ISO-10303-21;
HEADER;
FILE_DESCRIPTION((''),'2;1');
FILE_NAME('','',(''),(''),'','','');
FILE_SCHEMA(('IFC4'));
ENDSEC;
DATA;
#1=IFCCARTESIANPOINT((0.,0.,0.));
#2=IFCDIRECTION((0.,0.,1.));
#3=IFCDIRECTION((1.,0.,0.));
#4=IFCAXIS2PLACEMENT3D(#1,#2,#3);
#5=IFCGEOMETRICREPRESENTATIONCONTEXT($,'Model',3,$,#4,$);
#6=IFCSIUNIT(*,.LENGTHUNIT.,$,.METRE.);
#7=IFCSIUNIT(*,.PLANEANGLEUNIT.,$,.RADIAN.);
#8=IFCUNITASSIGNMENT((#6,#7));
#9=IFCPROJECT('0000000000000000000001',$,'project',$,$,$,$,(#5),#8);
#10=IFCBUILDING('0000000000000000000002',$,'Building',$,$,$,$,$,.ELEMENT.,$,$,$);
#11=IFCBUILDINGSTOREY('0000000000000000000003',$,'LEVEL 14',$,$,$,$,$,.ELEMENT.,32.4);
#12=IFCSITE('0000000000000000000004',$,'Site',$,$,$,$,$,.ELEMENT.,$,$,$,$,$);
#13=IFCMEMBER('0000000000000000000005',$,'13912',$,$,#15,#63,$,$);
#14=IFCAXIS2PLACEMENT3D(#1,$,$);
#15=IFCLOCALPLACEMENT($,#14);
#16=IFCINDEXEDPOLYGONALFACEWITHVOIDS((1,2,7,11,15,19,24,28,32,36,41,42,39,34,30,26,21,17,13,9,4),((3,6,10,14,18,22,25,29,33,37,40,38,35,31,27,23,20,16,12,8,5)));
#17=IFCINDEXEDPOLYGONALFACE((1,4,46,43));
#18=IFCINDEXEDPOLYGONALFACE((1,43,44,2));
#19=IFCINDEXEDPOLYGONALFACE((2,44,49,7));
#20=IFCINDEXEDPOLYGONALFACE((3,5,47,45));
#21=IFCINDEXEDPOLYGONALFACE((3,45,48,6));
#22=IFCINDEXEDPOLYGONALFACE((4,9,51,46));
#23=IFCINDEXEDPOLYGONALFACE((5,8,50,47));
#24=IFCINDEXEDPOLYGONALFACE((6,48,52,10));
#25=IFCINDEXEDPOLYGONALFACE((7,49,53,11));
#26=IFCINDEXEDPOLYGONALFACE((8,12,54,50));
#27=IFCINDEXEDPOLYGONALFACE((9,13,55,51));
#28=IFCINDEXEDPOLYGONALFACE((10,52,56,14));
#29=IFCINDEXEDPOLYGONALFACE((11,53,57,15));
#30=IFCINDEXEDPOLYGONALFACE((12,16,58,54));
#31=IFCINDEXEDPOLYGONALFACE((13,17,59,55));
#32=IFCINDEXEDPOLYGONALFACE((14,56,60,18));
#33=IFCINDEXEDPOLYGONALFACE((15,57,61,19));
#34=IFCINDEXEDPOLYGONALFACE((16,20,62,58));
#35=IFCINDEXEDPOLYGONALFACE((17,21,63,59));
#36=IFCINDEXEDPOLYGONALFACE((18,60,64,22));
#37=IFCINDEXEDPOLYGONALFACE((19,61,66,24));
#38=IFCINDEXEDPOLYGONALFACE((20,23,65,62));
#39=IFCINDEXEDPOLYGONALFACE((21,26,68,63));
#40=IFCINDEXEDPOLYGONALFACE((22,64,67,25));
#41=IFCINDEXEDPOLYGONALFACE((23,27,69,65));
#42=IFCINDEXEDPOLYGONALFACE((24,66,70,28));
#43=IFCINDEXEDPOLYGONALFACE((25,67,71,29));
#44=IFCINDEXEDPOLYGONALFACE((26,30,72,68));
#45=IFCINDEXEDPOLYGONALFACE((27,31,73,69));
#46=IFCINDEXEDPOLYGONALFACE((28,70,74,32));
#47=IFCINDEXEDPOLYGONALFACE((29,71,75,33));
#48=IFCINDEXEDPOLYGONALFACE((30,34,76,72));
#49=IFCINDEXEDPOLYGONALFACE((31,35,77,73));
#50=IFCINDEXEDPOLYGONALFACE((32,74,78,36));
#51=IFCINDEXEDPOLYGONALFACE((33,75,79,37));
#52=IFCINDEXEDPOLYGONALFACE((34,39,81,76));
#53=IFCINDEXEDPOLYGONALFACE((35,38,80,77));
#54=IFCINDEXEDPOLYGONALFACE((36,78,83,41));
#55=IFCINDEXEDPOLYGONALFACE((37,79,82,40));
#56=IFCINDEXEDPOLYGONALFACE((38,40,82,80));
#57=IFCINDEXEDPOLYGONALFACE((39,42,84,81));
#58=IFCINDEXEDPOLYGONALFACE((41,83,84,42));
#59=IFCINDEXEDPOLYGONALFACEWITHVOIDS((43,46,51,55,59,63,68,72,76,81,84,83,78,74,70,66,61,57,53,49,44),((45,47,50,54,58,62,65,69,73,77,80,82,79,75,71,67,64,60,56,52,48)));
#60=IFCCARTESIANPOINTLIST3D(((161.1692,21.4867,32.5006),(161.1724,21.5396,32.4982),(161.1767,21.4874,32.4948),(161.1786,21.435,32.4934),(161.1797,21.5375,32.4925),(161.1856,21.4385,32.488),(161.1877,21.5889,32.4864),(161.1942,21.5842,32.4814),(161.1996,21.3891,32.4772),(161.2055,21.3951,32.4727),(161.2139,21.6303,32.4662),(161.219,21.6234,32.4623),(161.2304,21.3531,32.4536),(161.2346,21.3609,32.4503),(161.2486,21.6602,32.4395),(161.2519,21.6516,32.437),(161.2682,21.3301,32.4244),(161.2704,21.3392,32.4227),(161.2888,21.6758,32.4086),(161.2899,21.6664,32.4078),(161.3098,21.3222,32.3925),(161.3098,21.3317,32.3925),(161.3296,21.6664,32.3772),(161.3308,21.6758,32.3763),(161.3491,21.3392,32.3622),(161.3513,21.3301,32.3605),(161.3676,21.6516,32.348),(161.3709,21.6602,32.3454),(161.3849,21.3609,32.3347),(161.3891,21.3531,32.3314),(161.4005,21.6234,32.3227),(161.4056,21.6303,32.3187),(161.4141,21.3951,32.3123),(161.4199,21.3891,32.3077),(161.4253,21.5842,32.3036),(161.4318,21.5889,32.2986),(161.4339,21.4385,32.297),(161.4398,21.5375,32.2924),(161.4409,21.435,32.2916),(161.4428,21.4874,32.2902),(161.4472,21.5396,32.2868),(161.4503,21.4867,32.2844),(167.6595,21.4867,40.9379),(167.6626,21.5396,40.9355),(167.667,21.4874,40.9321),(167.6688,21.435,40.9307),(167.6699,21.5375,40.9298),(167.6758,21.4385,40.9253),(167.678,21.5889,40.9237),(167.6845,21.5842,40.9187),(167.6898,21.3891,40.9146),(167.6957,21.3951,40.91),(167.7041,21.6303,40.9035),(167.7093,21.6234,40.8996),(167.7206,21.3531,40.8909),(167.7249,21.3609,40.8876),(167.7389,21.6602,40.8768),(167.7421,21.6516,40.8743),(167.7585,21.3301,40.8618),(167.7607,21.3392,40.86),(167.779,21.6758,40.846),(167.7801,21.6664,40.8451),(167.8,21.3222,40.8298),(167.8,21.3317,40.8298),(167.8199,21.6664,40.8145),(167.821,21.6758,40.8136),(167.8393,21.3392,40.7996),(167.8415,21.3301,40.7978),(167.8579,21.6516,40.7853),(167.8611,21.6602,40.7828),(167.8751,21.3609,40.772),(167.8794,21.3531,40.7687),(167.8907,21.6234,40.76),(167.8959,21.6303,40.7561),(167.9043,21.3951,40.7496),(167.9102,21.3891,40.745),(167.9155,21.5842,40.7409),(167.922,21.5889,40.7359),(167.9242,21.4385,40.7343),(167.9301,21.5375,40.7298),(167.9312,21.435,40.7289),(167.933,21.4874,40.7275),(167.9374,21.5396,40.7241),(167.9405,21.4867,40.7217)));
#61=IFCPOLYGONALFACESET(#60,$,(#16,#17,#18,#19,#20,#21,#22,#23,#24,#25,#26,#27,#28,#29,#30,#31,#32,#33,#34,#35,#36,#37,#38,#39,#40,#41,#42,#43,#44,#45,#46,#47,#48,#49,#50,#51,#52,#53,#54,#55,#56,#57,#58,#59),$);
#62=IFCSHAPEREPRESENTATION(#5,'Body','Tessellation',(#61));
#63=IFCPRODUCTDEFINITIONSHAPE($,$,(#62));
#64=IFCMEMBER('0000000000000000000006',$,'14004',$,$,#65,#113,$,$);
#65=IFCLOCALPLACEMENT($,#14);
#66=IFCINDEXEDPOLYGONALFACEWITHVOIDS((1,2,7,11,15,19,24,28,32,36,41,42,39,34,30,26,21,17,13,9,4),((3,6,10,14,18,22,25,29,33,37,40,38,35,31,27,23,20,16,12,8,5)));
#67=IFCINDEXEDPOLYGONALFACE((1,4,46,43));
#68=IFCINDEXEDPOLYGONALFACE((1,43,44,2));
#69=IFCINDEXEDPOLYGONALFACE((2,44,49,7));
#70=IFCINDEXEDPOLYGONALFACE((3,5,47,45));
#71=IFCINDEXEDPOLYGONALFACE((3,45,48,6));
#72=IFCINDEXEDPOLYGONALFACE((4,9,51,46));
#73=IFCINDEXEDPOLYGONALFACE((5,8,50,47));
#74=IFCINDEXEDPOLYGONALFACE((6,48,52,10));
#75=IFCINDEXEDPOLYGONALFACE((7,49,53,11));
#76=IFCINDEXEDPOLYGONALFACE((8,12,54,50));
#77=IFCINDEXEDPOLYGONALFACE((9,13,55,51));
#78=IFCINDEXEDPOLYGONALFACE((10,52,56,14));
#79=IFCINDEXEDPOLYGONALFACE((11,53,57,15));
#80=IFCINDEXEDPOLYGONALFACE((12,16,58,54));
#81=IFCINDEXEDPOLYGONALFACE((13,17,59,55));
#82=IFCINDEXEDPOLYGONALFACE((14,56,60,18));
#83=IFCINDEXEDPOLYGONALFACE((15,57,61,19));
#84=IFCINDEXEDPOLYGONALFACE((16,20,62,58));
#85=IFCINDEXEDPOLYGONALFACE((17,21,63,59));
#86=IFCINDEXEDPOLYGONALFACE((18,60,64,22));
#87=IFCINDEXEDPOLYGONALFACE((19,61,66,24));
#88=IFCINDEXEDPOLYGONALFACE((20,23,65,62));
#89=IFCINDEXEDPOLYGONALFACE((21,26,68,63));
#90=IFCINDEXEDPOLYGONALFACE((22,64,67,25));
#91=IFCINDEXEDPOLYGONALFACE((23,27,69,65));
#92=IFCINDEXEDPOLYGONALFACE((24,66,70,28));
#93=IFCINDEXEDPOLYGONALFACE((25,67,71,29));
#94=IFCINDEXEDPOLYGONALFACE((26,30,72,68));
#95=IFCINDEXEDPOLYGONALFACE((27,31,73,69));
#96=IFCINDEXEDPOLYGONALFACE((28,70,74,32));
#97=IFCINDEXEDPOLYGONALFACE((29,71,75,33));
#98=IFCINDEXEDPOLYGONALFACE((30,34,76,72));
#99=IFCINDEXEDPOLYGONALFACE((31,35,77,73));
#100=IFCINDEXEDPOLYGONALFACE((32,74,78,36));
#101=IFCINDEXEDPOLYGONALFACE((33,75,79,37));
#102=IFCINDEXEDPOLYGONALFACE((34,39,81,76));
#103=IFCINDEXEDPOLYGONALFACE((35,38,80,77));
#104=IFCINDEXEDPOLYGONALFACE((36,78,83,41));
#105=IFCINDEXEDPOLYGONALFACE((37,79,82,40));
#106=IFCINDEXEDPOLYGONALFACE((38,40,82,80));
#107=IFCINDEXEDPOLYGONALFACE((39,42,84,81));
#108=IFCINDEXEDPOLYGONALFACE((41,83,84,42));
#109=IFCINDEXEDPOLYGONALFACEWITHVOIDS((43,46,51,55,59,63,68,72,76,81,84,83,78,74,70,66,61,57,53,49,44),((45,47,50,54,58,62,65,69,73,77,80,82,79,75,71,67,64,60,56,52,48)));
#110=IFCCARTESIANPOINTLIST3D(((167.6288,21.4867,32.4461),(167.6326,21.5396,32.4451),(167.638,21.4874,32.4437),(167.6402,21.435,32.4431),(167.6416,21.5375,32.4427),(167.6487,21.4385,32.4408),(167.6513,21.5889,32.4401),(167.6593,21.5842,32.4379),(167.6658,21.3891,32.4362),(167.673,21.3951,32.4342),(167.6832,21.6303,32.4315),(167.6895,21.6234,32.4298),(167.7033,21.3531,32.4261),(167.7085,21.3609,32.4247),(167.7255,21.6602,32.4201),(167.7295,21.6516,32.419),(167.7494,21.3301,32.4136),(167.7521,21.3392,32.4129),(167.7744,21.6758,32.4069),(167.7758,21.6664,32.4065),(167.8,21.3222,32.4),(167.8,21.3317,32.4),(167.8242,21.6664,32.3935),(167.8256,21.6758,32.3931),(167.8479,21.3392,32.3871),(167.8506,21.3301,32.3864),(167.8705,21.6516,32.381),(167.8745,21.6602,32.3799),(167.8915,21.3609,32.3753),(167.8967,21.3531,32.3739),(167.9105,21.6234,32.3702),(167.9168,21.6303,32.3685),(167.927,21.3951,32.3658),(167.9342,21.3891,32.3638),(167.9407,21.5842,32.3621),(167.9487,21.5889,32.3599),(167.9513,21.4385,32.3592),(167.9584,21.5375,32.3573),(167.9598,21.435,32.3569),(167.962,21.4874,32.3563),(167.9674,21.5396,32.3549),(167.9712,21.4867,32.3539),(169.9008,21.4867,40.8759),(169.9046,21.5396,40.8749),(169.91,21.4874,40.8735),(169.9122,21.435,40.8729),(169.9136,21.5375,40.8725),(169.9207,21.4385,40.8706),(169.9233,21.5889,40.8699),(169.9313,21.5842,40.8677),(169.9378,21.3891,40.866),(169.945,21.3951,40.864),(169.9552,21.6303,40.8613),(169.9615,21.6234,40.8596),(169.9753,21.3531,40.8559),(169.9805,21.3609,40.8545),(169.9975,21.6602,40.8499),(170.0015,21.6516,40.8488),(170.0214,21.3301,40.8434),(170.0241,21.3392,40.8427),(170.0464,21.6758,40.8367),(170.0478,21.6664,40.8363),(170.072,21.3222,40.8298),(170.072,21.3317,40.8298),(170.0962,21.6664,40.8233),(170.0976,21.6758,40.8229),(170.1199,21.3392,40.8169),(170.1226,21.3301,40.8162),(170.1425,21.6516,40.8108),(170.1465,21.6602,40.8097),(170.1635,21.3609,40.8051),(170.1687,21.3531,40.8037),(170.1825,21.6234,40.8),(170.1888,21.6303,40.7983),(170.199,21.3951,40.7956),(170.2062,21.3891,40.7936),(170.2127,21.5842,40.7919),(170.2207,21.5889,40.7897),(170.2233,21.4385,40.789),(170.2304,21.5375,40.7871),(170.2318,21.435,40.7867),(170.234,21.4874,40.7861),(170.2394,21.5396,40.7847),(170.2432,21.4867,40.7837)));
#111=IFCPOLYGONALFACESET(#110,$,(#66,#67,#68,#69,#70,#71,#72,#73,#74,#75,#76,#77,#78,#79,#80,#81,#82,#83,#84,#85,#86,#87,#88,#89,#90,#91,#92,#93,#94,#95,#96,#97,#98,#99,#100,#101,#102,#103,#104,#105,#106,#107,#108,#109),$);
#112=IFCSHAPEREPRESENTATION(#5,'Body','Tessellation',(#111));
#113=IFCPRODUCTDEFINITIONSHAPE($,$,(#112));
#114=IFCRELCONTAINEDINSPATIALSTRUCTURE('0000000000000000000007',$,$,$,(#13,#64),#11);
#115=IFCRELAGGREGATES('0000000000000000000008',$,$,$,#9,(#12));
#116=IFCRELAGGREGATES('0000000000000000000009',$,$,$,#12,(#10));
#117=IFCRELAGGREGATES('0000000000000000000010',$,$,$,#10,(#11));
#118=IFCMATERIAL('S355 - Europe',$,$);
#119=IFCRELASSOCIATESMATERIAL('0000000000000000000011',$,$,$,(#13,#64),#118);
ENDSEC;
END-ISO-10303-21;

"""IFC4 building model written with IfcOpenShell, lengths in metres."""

from ifc_helpers import new_model, si_unit, frame, origin_with_axes, origin_2d_with_axis, place, context, project, spatial, hollow_circle, extrude, material, material_profile, profile_set, profile_usage, element, save


model = new_model("IFC4")

# Units and contexts
model_context = context("Model", 3, world=origin_with_axes())
ifc_project = project(units=[si_unit("LENGTHUNIT", "METRE"), si_unit("PLANEANGLEUNIT", "RADIAN")], contexts=[model_context])

# Site, building, storey
site = spatial("IfcSite", under=ifc_project, Name="Site", CompositionType="ELEMENT")
building = spatial("IfcBuilding", under=site, Name="Building", CompositionType="ELEMENT")
storey = spatial("IfcBuildingStorey", under=building, Name="LEVEL 14", CompositionType="ELEMENT", Elevation=32.4)

# Shared definitions
ifc_material = material(Name="S355 - Europe")

# Members
ifc_material_profile_1 = material_profile(ifc_material, hollow_circle(Radius=0.1778, WallThickness=0.0095, at=origin_2d_with_axis()))
ifc_profile_set_1 = profile_set([ifc_material_profile_1])
ifc_profile_usage_1 = profile_usage(ifc_profile_set_1, cardinal=10)
member_1_placement = place(None, frame((167.8, 21.5, 40.8298), z_axis=(-0.609711, 0.0, -0.792624), x_axis=(0.0, -1.0, 0.0)))
element("IfcMember", 1, at=member_1_placement, inside=storey, material=ifc_profile_usage_1, Name="13912", context=model_context, shape_type="SweptSolid", body=[
    extrude(hollow_circle(Radius=0.1778, WallThickness=0.0095, at=origin_2d_with_axis()), origin_with_axes(), (0.0, 0.0, 1.0), 10.6448),
])
ifc_material_profile_2 = material_profile(ifc_material, hollow_circle(Radius=0.1778, WallThickness=0.0095, at=origin_2d_with_axis()))
ifc_profile_set_2 = profile_set([ifc_material_profile_2])
ifc_profile_usage_2 = profile_usage(ifc_profile_set_2, cardinal=10)
member_2_placement = place(None, frame((170.072, 21.5, 40.8298), z_axis=(-0.260234, 0.0, -0.965546), x_axis=(0.0, -1.0, 0.0)))
element("IfcMember", 2, at=member_2_placement, inside=storey, material=ifc_profile_usage_2, Name="14004", context=model_context, shape_type="SweptSolid", body=[
    extrude(hollow_circle(Radius=0.1778, WallThickness=0.0095, at=origin_2d_with_axis()), origin_with_axes(), (0.0, 0.0, 1.0), 8.7306),
])

save(model, "model.ifc")
